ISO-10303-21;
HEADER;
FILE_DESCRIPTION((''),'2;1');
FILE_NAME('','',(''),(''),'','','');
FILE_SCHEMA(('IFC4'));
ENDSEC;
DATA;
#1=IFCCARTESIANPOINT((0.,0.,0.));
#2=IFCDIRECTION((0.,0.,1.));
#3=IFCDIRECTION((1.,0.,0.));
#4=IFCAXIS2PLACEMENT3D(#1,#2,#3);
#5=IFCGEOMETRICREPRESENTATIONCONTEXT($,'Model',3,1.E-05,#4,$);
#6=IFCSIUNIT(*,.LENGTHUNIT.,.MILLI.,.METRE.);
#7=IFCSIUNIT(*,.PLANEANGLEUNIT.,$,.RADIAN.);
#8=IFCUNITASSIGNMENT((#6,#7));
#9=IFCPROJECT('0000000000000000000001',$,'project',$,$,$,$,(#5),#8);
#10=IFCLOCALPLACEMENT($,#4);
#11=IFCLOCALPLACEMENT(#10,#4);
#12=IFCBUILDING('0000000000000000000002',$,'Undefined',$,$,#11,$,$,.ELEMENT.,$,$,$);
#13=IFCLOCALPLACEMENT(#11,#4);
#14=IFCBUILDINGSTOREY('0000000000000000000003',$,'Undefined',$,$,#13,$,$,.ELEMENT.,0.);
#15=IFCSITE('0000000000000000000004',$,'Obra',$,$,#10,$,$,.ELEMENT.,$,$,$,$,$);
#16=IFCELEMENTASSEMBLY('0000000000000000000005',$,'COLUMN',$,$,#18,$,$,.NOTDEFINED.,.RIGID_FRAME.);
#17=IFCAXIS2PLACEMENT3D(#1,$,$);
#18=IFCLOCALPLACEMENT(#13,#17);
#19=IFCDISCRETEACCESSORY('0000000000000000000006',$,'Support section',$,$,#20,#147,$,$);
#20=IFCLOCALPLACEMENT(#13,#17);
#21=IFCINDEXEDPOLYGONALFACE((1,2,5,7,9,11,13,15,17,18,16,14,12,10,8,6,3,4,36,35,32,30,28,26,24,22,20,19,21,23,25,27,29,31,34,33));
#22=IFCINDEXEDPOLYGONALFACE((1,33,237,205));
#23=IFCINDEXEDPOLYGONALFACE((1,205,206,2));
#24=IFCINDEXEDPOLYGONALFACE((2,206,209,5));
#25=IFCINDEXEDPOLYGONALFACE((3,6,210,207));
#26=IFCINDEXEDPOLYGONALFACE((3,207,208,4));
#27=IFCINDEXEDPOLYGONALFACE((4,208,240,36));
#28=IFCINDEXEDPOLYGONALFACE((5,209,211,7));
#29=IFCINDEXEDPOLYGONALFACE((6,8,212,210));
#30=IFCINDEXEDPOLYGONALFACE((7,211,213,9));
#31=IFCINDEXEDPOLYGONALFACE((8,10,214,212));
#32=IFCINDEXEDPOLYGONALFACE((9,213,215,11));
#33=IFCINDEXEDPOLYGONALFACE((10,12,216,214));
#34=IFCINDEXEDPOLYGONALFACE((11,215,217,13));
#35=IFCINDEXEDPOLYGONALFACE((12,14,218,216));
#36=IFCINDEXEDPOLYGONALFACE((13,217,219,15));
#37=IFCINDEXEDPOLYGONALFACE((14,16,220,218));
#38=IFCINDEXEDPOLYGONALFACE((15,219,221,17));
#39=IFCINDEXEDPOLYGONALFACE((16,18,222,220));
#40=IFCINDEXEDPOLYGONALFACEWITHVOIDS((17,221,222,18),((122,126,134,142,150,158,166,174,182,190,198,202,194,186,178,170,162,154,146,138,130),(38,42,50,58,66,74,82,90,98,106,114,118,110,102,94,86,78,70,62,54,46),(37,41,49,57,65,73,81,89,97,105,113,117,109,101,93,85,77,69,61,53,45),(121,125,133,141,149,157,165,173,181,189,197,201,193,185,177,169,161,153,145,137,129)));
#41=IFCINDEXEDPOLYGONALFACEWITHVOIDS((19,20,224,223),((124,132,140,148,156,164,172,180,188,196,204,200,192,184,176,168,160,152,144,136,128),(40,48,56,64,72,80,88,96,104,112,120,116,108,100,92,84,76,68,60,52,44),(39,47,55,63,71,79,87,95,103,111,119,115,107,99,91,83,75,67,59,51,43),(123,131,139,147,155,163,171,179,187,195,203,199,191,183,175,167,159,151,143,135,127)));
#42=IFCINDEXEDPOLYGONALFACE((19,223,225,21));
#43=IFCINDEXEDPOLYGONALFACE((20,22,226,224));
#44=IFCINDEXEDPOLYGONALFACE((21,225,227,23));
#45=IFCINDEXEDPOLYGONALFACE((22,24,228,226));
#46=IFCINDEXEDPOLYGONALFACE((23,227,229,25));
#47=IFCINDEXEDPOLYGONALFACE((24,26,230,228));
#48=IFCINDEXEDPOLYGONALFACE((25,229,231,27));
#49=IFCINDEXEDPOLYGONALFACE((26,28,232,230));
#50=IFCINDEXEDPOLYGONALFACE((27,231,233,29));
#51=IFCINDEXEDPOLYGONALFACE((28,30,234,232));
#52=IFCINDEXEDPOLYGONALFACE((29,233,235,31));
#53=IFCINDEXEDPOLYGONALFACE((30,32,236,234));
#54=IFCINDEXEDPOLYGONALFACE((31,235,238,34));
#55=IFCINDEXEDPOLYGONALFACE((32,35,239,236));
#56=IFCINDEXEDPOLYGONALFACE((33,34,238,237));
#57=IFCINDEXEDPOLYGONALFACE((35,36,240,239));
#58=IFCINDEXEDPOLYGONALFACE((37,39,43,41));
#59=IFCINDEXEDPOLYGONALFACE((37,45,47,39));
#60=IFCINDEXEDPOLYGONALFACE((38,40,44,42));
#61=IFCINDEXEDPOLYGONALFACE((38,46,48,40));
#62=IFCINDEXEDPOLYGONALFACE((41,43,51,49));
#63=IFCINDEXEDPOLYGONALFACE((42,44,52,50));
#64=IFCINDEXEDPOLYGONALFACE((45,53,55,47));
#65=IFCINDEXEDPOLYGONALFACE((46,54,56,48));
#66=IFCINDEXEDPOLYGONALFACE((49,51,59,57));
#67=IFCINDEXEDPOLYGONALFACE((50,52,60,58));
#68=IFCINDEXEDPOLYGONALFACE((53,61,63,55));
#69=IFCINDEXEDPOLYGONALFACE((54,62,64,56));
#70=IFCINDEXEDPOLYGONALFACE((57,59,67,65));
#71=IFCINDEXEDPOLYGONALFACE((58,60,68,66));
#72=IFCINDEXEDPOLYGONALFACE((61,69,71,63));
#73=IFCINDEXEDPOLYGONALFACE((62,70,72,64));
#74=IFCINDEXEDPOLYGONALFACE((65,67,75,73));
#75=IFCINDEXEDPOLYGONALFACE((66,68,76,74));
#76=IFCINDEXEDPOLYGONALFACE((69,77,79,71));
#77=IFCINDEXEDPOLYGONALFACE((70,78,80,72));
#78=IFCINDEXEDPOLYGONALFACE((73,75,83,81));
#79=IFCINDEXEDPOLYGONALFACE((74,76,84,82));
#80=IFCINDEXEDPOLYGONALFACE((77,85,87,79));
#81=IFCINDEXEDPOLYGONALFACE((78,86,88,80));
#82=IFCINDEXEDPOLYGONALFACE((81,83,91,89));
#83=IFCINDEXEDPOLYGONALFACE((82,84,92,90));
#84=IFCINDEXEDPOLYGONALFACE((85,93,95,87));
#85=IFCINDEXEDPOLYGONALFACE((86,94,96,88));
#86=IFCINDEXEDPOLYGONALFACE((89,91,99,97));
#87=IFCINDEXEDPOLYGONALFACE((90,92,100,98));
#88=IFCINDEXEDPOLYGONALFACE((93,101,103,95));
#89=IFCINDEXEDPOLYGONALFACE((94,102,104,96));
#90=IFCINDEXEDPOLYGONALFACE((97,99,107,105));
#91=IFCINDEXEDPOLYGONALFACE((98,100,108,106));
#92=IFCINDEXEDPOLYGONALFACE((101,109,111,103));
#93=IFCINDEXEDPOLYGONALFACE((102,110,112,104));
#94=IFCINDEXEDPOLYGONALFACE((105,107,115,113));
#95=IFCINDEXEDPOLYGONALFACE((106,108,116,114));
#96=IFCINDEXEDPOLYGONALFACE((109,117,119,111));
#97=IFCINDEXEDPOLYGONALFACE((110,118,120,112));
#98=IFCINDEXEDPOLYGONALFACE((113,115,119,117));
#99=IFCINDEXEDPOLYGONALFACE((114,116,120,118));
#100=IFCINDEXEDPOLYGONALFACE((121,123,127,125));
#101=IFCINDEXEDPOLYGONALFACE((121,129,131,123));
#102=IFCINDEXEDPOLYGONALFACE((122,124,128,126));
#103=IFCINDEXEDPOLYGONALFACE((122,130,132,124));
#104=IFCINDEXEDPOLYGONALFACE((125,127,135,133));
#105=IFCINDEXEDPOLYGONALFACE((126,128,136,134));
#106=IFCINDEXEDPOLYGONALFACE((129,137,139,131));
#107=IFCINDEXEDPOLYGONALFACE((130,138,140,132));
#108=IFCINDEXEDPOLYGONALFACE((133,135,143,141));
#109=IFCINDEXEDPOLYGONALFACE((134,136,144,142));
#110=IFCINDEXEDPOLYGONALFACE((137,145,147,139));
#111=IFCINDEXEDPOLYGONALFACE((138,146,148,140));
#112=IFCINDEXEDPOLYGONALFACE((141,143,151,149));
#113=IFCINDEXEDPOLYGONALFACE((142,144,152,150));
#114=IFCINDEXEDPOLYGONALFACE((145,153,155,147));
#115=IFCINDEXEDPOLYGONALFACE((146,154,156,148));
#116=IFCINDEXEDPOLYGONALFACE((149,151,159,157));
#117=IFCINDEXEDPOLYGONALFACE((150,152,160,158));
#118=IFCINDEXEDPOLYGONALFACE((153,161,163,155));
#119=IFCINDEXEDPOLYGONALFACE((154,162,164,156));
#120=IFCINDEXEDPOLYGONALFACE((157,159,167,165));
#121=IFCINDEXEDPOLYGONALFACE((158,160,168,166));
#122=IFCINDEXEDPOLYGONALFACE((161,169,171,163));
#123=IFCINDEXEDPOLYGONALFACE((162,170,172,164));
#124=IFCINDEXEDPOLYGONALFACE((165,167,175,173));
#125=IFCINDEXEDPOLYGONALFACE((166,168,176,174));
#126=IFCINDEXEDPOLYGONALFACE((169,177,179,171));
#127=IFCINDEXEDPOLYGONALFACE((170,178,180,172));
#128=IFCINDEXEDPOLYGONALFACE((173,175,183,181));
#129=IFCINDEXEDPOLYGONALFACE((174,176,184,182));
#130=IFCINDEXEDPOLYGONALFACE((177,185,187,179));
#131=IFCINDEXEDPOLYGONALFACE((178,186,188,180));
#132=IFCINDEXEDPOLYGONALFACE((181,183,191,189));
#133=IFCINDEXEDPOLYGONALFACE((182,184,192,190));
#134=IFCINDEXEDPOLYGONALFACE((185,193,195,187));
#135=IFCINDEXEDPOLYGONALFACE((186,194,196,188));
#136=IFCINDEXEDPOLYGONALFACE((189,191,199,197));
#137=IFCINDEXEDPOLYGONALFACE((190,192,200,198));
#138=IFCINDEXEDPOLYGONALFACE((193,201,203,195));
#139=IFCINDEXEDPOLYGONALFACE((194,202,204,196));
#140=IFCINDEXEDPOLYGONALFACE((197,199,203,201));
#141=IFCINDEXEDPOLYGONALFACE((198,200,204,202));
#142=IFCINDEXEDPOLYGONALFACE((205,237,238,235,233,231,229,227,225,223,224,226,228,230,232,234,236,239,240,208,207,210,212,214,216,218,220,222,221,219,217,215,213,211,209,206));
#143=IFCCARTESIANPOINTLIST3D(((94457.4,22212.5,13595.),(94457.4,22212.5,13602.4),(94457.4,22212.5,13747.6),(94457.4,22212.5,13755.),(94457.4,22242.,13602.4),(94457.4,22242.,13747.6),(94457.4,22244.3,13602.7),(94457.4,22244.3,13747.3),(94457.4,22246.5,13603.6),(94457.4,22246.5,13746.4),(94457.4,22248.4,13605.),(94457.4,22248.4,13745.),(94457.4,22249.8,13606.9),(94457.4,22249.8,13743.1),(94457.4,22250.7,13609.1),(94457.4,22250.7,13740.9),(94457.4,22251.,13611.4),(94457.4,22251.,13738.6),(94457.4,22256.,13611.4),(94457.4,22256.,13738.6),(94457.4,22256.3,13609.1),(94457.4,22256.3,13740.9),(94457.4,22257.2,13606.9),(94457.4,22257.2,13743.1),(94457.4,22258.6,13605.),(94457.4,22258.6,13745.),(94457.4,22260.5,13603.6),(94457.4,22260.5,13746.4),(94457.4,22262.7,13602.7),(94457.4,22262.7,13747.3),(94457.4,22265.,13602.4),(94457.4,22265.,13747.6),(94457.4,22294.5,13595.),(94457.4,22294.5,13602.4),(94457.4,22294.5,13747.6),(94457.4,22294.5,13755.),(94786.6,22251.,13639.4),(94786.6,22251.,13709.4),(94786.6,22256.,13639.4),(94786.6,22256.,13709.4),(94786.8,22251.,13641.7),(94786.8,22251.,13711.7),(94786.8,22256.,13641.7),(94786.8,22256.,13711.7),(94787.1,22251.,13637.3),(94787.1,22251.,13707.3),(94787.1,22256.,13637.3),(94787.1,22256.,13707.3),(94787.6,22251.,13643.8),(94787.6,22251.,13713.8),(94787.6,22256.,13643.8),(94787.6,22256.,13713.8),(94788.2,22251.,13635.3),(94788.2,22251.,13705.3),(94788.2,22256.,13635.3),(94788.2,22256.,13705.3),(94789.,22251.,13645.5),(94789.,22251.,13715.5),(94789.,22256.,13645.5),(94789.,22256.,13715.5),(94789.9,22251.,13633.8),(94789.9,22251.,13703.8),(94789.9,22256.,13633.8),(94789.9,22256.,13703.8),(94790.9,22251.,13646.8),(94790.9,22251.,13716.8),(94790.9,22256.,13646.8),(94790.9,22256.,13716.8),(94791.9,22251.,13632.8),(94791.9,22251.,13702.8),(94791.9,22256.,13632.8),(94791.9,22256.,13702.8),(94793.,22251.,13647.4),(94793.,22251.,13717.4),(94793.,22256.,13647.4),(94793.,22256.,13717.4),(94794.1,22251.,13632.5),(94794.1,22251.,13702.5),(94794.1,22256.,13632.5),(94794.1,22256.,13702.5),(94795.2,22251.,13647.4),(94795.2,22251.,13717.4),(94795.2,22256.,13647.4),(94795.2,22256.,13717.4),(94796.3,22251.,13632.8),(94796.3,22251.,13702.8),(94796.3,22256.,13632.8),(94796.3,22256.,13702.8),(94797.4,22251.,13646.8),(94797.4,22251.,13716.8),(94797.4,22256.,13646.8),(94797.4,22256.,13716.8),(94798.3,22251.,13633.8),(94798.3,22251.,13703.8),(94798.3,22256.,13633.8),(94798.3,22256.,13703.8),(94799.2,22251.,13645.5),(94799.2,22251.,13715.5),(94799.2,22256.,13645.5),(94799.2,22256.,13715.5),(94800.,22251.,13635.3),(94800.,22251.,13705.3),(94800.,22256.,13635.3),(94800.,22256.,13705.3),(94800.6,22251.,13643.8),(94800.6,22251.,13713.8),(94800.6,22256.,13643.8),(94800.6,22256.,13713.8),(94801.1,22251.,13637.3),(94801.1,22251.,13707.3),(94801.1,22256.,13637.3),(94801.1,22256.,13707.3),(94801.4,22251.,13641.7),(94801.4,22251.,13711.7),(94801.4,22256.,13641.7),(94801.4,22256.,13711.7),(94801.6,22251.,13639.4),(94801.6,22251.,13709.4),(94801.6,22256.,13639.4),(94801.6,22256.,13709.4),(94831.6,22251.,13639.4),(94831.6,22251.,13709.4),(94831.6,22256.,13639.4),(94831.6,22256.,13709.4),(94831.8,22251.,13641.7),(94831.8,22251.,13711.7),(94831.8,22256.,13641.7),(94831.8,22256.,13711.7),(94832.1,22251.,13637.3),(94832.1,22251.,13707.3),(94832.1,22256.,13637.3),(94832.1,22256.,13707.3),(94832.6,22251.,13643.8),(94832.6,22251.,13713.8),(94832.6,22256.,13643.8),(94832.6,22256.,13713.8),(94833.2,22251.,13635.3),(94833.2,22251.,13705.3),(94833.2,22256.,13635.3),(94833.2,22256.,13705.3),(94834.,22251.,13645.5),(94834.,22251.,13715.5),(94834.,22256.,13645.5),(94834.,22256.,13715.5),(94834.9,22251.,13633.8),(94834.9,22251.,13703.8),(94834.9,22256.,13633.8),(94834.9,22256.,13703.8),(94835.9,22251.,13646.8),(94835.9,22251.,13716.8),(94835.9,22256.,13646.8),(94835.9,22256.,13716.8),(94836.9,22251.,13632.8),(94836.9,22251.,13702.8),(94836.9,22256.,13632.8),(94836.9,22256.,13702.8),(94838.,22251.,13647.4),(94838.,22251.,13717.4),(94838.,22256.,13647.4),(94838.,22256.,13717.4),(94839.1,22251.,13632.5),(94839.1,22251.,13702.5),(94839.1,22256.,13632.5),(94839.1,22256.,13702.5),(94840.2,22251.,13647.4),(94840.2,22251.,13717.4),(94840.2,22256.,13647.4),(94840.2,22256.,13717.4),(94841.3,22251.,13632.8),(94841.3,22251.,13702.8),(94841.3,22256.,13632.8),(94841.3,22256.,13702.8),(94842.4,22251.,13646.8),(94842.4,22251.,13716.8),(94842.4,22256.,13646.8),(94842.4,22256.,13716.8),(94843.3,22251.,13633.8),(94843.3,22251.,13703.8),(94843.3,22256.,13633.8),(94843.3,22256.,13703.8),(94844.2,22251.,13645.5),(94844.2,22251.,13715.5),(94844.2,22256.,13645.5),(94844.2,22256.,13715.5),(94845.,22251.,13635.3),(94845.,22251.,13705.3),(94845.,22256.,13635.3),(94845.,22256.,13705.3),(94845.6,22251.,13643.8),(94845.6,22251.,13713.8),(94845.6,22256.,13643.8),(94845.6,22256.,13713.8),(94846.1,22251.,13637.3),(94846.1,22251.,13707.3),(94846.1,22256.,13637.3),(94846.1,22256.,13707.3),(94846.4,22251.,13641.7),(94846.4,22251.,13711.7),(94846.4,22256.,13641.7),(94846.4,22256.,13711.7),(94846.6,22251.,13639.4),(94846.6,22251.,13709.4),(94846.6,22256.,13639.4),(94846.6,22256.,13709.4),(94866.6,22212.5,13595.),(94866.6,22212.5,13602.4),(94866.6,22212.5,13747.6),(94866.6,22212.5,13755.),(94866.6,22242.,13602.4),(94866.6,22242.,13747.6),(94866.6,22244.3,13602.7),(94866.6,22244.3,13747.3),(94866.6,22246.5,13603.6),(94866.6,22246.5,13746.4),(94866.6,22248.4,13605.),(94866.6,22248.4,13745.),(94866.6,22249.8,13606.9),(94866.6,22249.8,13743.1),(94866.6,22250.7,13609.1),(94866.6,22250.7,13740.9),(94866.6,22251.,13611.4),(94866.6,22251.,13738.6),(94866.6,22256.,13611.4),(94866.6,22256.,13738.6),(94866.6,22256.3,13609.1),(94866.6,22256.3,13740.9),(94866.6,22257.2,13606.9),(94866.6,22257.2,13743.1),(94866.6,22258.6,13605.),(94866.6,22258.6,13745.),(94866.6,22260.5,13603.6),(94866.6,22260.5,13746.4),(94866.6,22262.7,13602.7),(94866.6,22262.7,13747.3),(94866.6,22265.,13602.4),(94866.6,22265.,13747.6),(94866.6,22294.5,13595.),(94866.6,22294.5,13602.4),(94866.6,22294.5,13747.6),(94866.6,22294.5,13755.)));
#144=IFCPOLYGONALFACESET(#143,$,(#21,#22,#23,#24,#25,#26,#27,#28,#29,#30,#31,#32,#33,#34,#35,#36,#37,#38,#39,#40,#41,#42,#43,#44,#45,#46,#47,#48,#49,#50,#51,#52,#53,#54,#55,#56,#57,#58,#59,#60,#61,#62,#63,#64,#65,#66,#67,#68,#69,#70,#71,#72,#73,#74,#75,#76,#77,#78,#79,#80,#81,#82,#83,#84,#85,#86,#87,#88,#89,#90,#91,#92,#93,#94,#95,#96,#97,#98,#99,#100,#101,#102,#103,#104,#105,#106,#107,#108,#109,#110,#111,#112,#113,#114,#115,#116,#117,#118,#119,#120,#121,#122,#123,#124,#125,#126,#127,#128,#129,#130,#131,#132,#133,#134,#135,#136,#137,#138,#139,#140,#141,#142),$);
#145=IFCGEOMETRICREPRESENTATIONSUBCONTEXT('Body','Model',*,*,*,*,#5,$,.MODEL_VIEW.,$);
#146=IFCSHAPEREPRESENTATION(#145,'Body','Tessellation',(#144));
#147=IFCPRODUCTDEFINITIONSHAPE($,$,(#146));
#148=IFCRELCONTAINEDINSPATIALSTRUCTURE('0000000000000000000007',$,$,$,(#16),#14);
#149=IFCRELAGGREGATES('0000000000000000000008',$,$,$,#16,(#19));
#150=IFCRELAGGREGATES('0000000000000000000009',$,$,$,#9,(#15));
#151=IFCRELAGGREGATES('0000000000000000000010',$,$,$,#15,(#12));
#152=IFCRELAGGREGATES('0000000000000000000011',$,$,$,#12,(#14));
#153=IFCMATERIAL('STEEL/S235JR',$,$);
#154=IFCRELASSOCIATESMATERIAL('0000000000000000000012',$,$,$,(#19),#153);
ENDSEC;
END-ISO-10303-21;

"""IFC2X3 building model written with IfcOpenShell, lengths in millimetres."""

from ifc_helpers import new_model, si_unit, frame, origin_with_axes, origin_2d_with_axis, place, context, subcontext, project, spatial, circle, i_section, extrude, clip, halfspace, source, transform, mapped, material, element, aggregate, save


model = new_model("IFC2X3")

# Units and contexts
model_context = context("Model", 3, precision=1e-05, world=origin_with_axes())
body_context = subcontext(model_context, "Body", "Model", "MODEL_VIEW")
ifc_project = project(units=[si_unit("LENGTHUNIT", "METRE", prefix="MILLI"), si_unit("PLANEANGLEUNIT", "RADIAN")], contexts=[model_context])

# Site, building, storey
site_placement = place(None, origin_with_axes())
site = spatial("IfcSite", under=ifc_project, at=site_placement, Name="Obra", CompositionType="ELEMENT")
building_placement = place(site_placement, origin_with_axes())
building = spatial("IfcBuilding", under=site, at=building_placement, Name="Undefined", CompositionType="ELEMENT")
storey_placement = place(building_placement, origin_with_axes())
storey = spatial("IfcBuildingStorey", under=building, at=storey_placement, Name="Undefined", CompositionType="ELEMENT", Elevation=0.0)

# Shared definitions
ifc_material_1 = material(Name="STEEL/S235JR")

# Element assembly, discrete accessory, opening
assembly_1_placement = place(storey_placement, origin_with_axes())
assembly_1 = element("IfcElementAssembly", 1, at=assembly_1_placement, inside=storey, Name="COLUMN", AssemblyPlace="NOTDEFINED", PredefinedType="RIGID_FRAME")
shared_shape_1 = source(origin_with_axes(), body_context, "Body", "SweptSolid", [
    extrude(circle(Radius=7.5, at=origin_2d_with_axis()), frame((0.0, -2.6, 0.0), z_axis=(0.0, 1.0, 0.0), x_axis=(1.0, 0.0, 0.0)), (0.0, 0.0, 1.0), 5.2),
])
discrete_accessory_1_placement = place(assembly_1_placement, frame((94458.3, 22253.5, 13675.0), z_axis=(0.0, 0.0, 1.0), x_axis=(1.0, 0.0, 0.0)))
discrete_accessory_1 = element("IfcDiscreteAccessory", 2, at=discrete_accessory_1_placement, material=ifc_material_1, Name="Support section", context=body_context, shape_type="Clipping", body=[
    clip(clip(extrude(i_section(OverallWidth=82.0, OverallDepth=160.0, WebThickness=5.0, FlangeThickness=7.4, FilletRadius=9.0, at=origin_2d_with_axis()), frame((408.3, 0.0, 0.0), z_axis=(-1.0, 0.0, 0.0), x_axis=(0.0, -1.0, 0.0)), (0.0, 0.0, 1.0), 409.2), halfspace(frame((408.3, 0.0, -180.0), z_axis=(-1.0, 0.0, 0.0), x_axis=(0.0, 1.0, 0.0)), True)), halfspace(frame((-0.9, 0.0, 580.0), z_axis=(-1.0, -0.000033, 0.0), x_axis=(0.000033, -1.0, 0.0)), False)),
])
opening_1_placement = place(assembly_1_placement, frame((94816.6, 22253.5, 13710.0), z_axis=(-1.0, 0.0, 0.0), x_axis=(0.0, 0.0, -1.0)))
element("IfcOpeningElement", 3, at=opening_1_placement, cuts=discrete_accessory_1, ObjectType="Opening", context=body_context, shape_type="MappedRepresentation", body=[
    mapped(shared_shape_1, transform((0.0, 0.0, -22.5))),
    mapped(shared_shape_1, transform((70.0, 0.0, -22.5))),
    mapped(shared_shape_1, transform((0.0, 0.0, 22.5))),
    mapped(shared_shape_1, transform((70.0, 0.0, 22.5))),
])
aggregate(assembly_1, [discrete_accessory_1])

save(model, "model.ifc")
